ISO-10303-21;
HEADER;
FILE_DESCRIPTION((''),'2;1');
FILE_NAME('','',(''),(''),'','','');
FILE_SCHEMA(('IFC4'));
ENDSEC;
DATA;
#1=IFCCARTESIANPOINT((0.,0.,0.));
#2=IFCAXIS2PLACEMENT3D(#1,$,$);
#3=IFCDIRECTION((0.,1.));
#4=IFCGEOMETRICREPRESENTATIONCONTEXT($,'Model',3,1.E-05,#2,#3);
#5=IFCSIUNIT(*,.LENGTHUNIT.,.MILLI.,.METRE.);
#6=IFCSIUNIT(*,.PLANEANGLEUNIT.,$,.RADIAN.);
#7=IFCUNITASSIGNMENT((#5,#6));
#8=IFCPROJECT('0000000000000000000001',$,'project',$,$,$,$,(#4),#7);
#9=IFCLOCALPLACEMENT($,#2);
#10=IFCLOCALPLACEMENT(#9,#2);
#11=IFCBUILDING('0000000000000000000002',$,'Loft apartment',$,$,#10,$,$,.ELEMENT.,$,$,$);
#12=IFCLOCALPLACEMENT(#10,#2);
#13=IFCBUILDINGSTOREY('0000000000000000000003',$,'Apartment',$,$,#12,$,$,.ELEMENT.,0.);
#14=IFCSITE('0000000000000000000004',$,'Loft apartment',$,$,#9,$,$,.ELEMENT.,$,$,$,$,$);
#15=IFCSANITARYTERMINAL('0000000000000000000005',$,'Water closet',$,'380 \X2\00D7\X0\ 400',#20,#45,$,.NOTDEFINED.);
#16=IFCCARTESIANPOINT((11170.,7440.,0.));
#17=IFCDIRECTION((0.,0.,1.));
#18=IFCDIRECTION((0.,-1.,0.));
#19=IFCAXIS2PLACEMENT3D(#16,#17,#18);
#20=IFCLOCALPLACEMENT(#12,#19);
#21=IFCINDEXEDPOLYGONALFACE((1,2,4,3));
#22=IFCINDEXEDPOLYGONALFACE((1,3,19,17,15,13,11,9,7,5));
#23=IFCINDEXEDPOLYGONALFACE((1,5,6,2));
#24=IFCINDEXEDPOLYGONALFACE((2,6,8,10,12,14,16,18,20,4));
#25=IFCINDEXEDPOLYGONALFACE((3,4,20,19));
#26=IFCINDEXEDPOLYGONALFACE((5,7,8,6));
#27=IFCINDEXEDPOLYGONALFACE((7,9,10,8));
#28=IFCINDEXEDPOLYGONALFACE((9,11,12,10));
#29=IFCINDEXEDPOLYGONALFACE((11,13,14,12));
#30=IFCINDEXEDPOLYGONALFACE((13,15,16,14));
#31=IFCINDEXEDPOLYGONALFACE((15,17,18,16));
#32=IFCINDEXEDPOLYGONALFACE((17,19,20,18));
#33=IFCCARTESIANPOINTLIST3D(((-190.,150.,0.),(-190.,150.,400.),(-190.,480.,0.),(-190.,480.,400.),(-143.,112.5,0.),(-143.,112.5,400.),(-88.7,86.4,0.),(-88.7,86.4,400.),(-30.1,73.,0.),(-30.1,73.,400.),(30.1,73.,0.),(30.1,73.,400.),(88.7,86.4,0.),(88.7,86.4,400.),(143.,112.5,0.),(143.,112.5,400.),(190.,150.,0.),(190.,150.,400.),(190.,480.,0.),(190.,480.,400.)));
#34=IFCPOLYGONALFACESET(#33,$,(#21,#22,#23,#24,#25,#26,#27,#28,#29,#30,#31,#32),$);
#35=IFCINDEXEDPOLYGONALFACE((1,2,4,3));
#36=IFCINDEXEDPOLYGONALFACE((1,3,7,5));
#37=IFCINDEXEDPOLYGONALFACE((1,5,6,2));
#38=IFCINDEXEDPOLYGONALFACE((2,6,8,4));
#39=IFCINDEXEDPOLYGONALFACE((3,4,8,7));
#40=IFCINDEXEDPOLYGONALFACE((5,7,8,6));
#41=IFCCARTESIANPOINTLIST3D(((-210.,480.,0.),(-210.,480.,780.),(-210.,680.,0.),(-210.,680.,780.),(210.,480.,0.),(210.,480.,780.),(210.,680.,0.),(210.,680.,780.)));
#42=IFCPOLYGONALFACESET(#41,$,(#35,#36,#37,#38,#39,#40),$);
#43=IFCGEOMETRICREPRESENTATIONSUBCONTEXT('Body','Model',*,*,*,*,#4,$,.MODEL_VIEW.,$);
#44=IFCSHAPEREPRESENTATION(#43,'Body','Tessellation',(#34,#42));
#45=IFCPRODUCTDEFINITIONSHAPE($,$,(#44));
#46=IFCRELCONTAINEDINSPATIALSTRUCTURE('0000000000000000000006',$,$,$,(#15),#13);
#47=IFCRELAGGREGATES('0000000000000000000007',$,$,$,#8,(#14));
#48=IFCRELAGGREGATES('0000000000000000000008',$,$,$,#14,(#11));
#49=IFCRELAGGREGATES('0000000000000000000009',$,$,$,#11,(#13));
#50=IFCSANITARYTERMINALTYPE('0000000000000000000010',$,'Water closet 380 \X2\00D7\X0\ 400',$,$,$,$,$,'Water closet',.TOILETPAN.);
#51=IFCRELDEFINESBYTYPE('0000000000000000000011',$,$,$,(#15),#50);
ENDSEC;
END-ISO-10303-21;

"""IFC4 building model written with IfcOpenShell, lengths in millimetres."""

from ifc_helpers import new_model, si_unit, direction, frame, origin, origin_with_axes, place, context, subcontext, project, spatial, polyline, line, arc, indexed_curve, outline, extrude, source, transform, mapped, type_object, type_shapes, element, save


model = new_model("IFC4")

# Units and contexts
model_context = context("Model", 3, precision=1e-05, world=origin(), true_north=direction((0.0, 1.0)))
body_context = subcontext(model_context, "Body", "Model", "MODEL_VIEW")
ifc_project = project(units=[si_unit("LENGTHUNIT", "METRE", prefix="MILLI"), si_unit("PLANEANGLEUNIT", "RADIAN")], contexts=[model_context])

# Site, building, storey
site_placement = place(None, origin())
site = spatial("IfcSite", under=ifc_project, at=site_placement, Name="Loft apartment", CompositionType="ELEMENT")
building_placement = place(site_placement, origin())
building = spatial("IfcBuilding", under=site, at=building_placement, Name="Loft apartment", CompositionType="ELEMENT")
storey_placement = place(building_placement, origin())
storey = spatial("IfcBuildingStorey", under=building, at=storey_placement, Name="Apartment", CompositionType="ELEMENT", Elevation=0.0)

# Sanitary terminal
sanitary_terminal_type_1 = type_object("IfcSanitaryTerminalType", Name="Water closet 380 × 400", ElementType="Water closet", PredefinedType="TOILETPAN")
shared_shape_1 = source(origin(), body_context, "Body", "SweptSolid", [
    extrude(outline(indexed_curve([(-190.0, 480.0), (-190.0, 150.0), (0.0, 71.3), (190.0, 150.0), (190.0, 480.0)], segments=[line(1, 2), arc(2, 3, 4), line(4, 5), line(5, 1)], self_intersect=False)), origin_with_axes(), (0.0, 0.0, 1.0), 400.0),
    extrude(outline(polyline([(-210.0, 480.0), (210.0, 480.0), (210.0, 680.0), (-210.0, 680.0), (-210.0, 480.0)])), origin(), (0.0, 0.0, 1.0), 780.0),
])
type_shapes(sanitary_terminal_type_1, [shared_shape_1])
sanitary_terminal_1_placement = place(storey_placement, frame((11170.0, 7440.0, 0.0), z_axis=(0.0, 0.0, 1.0), x_axis=(0.0, -1.0, 0.0)))
element("IfcSanitaryTerminal", 1, at=sanitary_terminal_1_placement, inside=storey, type_object=sanitary_terminal_type_1, Name="Water closet", ObjectType="380 × 400", PredefinedType="NOTDEFINED", context=body_context, shape_type="MappedRepresentation", body=[
    mapped(shared_shape_1, transform((0.0, 0.0, 0.0))),
])

save(model, "model.ifc")
